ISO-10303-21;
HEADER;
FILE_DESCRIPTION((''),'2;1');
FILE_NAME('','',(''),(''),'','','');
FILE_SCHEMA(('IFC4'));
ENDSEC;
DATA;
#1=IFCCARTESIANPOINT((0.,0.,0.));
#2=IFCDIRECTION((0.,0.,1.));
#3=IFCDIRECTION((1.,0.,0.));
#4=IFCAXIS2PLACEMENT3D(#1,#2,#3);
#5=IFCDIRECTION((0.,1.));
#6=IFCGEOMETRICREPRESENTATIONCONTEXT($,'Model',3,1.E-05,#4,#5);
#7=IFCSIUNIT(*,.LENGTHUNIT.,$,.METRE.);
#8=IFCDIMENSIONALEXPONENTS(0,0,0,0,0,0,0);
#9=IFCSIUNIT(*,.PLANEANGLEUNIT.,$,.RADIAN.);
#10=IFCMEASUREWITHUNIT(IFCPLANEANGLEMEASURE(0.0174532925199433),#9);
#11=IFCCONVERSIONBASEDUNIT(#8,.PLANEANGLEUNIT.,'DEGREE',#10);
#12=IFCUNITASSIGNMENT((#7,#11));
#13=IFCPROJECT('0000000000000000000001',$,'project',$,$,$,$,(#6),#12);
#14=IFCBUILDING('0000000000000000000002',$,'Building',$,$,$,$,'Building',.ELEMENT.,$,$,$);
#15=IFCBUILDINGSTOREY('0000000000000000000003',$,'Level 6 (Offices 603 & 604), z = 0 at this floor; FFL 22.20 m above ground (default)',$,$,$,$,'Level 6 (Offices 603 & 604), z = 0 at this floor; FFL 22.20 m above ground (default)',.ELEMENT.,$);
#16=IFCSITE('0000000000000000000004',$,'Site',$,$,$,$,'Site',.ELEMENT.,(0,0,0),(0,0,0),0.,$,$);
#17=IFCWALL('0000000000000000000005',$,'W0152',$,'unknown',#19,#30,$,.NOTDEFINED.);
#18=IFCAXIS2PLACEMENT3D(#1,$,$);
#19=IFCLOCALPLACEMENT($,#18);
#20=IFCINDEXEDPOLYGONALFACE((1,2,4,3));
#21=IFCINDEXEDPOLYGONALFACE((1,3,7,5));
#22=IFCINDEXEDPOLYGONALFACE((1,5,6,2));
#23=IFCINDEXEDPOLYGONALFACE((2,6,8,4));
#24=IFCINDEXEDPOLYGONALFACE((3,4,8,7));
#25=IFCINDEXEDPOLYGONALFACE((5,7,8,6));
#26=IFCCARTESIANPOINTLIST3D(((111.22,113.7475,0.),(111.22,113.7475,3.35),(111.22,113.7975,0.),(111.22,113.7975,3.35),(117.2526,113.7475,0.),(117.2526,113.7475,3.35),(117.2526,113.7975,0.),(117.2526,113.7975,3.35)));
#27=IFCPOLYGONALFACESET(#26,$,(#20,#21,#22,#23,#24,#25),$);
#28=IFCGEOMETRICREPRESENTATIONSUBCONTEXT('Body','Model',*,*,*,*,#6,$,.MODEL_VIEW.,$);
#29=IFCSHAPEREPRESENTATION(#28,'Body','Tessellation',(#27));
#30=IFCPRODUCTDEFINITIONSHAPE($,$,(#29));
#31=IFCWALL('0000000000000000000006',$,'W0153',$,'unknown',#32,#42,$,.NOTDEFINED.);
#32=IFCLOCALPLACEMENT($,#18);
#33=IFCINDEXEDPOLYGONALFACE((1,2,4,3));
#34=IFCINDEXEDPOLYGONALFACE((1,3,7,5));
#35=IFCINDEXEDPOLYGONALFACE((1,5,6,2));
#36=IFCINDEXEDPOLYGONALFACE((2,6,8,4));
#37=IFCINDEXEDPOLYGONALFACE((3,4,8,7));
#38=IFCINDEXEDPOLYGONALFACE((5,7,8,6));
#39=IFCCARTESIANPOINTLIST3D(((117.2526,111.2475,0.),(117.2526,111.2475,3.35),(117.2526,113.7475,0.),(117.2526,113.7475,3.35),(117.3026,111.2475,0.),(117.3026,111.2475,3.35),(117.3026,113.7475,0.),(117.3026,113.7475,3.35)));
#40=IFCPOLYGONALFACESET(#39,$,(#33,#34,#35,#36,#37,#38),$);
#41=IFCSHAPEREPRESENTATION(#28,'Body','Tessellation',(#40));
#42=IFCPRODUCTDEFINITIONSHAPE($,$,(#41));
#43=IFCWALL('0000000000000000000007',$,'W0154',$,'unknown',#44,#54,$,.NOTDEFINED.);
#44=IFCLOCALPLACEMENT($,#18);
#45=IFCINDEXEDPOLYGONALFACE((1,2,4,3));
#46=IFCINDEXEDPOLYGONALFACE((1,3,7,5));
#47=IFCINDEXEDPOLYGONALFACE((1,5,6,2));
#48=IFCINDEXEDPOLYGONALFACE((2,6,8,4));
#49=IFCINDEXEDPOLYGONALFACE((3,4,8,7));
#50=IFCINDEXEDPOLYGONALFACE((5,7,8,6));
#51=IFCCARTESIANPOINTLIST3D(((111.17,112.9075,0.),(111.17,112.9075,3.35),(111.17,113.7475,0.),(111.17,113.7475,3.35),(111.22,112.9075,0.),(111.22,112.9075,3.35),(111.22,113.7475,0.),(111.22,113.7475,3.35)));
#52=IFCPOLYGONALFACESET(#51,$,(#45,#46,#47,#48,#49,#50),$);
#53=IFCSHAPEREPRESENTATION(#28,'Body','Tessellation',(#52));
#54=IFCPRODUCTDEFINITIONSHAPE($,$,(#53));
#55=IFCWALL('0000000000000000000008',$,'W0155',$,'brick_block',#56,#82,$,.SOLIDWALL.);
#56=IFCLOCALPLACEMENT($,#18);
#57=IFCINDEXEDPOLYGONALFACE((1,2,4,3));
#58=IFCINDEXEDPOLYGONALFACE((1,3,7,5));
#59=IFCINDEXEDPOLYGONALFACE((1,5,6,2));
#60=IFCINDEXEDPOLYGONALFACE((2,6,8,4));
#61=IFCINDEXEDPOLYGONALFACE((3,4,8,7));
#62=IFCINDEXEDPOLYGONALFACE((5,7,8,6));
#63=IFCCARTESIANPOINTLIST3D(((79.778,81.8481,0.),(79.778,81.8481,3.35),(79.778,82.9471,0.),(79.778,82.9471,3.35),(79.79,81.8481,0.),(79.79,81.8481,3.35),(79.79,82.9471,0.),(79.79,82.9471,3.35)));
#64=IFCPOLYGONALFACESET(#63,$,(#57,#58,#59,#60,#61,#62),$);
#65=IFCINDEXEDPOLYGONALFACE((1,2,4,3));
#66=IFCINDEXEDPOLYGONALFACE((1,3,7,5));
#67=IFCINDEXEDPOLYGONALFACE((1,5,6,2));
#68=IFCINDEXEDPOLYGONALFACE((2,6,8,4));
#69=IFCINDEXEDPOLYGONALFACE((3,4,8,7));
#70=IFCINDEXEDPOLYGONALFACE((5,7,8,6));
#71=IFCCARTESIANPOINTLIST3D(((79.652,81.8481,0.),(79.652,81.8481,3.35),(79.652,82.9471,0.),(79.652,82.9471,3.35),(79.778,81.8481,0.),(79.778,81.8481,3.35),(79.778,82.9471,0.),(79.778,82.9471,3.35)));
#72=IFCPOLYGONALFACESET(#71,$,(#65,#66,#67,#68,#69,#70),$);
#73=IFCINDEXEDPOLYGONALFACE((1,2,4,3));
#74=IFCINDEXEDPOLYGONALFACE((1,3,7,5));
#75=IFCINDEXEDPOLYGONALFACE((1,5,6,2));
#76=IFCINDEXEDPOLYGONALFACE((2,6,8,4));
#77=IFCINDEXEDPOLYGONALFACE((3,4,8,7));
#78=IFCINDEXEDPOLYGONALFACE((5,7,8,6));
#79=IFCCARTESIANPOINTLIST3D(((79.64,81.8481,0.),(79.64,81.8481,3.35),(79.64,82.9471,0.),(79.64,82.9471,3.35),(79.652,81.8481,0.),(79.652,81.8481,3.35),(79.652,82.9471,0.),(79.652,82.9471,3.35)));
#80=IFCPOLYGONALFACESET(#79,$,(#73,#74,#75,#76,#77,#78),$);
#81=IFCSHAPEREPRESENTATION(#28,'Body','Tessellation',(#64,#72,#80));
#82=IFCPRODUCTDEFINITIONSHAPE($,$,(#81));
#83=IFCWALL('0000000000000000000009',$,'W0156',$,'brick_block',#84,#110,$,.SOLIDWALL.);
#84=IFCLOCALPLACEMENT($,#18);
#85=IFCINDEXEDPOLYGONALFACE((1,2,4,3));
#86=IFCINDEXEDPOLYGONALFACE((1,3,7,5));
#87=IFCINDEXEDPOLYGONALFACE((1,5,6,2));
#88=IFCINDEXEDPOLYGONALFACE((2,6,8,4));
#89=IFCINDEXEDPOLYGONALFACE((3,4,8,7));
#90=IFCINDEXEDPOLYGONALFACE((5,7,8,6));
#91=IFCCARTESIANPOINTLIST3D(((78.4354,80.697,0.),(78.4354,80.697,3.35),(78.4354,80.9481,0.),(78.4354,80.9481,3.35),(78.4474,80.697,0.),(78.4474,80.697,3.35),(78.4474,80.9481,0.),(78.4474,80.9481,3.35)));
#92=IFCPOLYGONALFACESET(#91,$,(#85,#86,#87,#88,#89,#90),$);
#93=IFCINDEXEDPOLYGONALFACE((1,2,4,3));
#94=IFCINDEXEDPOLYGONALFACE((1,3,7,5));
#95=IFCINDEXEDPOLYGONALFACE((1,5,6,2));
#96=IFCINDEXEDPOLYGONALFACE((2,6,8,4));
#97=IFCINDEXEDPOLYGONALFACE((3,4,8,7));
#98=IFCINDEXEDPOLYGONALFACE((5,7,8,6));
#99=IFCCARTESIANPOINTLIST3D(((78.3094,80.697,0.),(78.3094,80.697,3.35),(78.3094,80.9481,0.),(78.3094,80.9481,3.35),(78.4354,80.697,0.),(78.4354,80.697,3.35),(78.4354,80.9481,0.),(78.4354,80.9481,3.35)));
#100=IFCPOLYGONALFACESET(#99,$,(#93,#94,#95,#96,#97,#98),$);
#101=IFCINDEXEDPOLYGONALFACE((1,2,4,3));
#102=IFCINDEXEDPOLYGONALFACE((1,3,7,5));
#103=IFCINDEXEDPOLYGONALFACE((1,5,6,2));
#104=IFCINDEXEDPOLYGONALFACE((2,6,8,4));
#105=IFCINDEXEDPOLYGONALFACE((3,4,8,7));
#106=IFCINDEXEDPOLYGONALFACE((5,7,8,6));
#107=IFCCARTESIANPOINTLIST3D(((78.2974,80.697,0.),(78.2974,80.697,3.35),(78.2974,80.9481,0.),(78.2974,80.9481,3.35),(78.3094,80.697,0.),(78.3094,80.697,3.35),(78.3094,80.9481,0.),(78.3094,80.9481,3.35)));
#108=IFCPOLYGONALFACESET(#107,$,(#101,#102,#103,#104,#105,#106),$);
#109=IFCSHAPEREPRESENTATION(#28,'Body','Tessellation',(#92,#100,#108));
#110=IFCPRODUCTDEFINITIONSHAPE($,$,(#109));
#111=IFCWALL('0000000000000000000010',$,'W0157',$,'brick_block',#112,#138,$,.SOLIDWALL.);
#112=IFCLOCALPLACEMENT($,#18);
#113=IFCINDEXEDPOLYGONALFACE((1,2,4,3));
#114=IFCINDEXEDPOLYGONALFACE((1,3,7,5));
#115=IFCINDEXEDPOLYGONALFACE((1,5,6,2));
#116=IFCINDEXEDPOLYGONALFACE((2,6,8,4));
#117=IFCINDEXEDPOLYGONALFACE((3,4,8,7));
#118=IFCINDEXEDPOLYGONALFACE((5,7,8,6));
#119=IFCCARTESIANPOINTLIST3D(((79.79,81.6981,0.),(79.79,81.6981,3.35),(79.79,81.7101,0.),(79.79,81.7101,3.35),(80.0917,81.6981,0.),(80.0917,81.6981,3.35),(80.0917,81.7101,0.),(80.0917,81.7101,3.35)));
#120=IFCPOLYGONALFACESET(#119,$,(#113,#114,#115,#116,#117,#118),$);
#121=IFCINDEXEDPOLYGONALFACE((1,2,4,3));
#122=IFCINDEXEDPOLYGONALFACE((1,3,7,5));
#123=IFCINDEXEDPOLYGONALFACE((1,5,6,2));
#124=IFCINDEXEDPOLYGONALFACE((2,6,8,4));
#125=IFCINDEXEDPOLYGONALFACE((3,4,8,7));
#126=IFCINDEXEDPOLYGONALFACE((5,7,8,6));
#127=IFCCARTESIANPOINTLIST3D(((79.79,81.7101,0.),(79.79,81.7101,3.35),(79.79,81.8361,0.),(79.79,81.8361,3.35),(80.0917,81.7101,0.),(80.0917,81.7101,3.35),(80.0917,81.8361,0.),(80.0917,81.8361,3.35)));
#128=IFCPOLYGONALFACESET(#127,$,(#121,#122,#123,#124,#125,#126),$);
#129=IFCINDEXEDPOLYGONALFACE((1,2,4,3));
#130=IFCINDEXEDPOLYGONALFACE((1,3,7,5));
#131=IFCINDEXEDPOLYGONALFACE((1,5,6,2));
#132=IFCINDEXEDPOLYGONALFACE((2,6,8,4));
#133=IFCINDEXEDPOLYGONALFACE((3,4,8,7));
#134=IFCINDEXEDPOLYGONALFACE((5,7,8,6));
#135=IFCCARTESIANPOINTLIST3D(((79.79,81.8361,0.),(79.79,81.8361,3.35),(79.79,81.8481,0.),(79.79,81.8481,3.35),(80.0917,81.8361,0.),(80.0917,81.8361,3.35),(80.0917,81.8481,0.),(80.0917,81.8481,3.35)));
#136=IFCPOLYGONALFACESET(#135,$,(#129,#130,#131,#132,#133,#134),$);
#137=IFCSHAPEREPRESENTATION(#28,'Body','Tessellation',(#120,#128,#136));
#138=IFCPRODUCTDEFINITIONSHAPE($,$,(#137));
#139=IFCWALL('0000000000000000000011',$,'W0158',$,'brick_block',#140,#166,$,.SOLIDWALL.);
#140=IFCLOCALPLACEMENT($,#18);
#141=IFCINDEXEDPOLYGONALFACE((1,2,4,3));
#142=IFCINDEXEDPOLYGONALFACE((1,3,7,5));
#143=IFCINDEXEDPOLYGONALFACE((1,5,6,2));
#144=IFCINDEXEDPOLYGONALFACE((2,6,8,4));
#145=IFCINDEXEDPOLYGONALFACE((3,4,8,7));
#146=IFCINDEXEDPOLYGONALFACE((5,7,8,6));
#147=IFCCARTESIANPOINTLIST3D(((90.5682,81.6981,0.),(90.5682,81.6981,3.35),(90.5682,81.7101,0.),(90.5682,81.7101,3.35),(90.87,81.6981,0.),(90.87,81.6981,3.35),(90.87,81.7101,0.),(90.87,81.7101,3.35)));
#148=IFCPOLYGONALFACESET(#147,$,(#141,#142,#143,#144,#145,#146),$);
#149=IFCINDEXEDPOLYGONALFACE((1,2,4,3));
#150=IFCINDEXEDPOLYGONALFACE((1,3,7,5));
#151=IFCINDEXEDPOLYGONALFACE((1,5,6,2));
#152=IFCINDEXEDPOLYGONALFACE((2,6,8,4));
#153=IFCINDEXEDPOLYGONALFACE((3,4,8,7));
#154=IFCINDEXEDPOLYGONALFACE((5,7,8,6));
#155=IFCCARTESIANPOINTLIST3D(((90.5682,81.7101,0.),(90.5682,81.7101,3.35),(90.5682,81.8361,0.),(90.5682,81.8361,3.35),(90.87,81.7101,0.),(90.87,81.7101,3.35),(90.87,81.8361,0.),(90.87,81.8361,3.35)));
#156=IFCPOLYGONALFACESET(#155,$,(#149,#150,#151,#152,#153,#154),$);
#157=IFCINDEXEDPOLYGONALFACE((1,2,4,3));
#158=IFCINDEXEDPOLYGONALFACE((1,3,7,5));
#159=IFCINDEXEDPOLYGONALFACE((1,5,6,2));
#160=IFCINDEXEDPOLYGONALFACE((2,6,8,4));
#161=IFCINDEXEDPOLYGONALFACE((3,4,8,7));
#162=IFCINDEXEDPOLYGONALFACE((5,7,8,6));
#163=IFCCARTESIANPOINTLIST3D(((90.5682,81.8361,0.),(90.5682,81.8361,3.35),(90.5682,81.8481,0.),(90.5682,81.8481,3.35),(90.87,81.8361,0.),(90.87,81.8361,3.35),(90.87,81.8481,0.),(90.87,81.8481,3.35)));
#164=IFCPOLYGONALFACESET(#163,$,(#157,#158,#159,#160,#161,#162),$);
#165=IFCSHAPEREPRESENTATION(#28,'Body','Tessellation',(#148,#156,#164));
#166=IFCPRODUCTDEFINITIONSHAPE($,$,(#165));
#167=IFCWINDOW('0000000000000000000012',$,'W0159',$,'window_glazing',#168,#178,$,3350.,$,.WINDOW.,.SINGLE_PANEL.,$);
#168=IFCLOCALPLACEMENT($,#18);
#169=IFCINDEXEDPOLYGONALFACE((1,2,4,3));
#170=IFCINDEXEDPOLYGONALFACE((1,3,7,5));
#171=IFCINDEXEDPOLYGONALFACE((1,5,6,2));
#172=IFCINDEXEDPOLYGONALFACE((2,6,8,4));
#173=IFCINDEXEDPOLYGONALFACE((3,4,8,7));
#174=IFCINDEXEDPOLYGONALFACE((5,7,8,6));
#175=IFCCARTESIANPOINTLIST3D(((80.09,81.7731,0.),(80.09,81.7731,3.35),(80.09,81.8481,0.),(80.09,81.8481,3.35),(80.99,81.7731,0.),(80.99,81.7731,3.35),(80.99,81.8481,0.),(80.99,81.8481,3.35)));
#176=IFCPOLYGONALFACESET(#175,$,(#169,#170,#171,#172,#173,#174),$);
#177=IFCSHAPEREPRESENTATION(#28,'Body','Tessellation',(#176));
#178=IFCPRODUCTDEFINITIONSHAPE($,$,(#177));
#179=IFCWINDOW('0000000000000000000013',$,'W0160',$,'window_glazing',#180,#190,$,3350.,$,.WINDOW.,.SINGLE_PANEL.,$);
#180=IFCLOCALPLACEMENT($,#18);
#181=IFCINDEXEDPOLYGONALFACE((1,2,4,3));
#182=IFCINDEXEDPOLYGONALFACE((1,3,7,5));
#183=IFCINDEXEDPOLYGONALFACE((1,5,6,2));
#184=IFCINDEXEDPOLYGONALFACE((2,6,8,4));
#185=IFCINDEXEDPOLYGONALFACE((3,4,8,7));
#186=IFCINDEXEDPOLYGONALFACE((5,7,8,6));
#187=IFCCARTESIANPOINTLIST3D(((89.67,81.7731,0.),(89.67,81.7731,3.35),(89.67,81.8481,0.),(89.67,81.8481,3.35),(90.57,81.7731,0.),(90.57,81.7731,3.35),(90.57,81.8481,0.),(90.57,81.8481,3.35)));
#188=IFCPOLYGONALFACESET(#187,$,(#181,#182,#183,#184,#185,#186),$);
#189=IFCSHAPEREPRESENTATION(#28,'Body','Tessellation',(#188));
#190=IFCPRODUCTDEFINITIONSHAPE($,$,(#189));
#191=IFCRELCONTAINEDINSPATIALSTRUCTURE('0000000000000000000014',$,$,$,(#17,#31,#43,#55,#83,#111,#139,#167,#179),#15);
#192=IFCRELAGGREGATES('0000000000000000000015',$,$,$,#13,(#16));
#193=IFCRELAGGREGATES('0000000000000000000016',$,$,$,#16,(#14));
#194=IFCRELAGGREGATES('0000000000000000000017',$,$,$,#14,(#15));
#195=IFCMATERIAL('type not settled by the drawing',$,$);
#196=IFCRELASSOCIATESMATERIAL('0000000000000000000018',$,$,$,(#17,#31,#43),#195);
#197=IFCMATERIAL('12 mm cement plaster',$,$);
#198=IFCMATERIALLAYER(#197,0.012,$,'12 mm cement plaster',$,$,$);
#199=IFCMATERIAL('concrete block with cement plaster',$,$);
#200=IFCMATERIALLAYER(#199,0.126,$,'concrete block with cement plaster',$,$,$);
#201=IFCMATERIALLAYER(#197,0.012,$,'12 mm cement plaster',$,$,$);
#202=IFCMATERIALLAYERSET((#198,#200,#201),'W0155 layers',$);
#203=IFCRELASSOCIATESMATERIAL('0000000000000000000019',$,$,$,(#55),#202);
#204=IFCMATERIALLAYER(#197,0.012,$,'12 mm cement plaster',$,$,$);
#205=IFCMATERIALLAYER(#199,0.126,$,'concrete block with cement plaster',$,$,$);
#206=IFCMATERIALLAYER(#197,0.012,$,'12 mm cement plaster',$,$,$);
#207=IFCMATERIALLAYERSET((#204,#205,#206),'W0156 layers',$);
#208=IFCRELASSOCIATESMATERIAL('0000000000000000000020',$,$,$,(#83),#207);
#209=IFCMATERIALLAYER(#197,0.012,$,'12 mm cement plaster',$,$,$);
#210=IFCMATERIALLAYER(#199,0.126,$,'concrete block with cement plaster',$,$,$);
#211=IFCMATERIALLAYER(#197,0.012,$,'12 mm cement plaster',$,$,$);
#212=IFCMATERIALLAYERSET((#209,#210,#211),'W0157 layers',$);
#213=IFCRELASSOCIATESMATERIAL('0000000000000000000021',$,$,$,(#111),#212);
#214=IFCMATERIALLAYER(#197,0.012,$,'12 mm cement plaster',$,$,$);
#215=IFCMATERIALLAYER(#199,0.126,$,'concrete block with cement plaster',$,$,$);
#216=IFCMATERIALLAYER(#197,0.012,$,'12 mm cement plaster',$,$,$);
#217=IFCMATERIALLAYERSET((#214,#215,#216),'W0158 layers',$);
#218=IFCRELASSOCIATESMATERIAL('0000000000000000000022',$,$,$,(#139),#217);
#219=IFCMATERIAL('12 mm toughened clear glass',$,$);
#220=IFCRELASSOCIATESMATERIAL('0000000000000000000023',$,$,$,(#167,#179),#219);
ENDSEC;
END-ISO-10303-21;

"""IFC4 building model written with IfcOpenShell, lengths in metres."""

from ifc_helpers import new_model, entity, si_unit, converted_unit, direction, frame, frame_2d, origin_with_axes, origin_2d_with_axis, place, context, subcontext, project, spatial, rectangle, extrude, material, layer, layer_set, layer_usage, element, save


model = new_model("IFC4")

# Units and contexts
model_context = context("Model", 3, precision=1e-05, world=origin_with_axes(), true_north=direction((0.0, 1.0)))
body_context = subcontext(model_context, "Body", "Model", "MODEL_VIEW")
ifc_project = project(units=[si_unit("LENGTHUNIT", "METRE"), converted_unit("PLANEANGLEUNIT", "DEGREE", entity("IfcPlaneAngleMeasure", 0.0174532925199433), si_unit("PLANEANGLEUNIT", "RADIAN"), dimensions=[0, 0, 0, 0, 0, 0, 0])], contexts=[model_context])

# Site, building, storey
site = spatial("IfcSite", under=ifc_project, Name="Site", LongName="Site", CompositionType="ELEMENT", RefLatitude=(0, 0, 0), RefLongitude=(0, 0, 0), RefElevation=0.0)
building = spatial("IfcBuilding", under=site, Name="Building", LongName="Building", CompositionType="ELEMENT")
storey = spatial("IfcBuildingStorey", under=building, Name="Level 6 (Offices 603 & 604), z = 0 at this floor; FFL 22.20 m above ground (default)", LongName="Level 6 (Offices 603 & 604), z = 0 at this floor; FFL 22.20 m above ground (default)", CompositionType="ELEMENT")

# Shared definitions
ifc_material_1 = material(Name="12 mm cement plaster")
ifc_material_2 = material(Name="concrete block with cement plaster")
placement = place(None, origin_with_axes())

# Shared definitions
ifc_material_3 = material(Name="12 mm toughened clear glass")

# Walls
ifc_material_4 = material(Name="type not settled by the drawing")
element("IfcWall", 1, at=placement, inside=storey, material=ifc_material_4, Name="W0152", ObjectType="unknown", PredefinedType="NOTDEFINED", context=body_context, shape_type="SweptSolid", body=[
    extrude(rectangle(XDim=6.0326, YDim=0.05, at=frame_2d((0.0, 0.0), x_axis=(1.0, 0.0))), frame((114.2363, 113.7725, 0.0), z_axis=(0.0, 0.0, 1.0), x_axis=(1.0, 0.0, 0.0)), (0.0, 0.0, 1.0), 3.35),
])
element("IfcWall", 2, at=placement, inside=storey, material=ifc_material_4, Name="W0153", ObjectType="unknown", PredefinedType="NOTDEFINED", context=body_context, shape_type="SweptSolid", body=[
    extrude(rectangle(XDim=2.5, YDim=0.05, at=frame_2d((0.0, 0.0), x_axis=(0.0, 1.0))), frame((117.2776, 112.4975, 0.0), z_axis=(0.0, 0.0, 1.0), x_axis=(1.0, 0.0, 0.0)), (0.0, 0.0, 1.0), 3.35),
])
element("IfcWall", 3, at=placement, inside=storey, material=ifc_material_4, Name="W0154", ObjectType="unknown", PredefinedType="NOTDEFINED", context=body_context, shape_type="SweptSolid", body=[
    extrude(rectangle(XDim=0.84, YDim=0.05, at=frame_2d((0.0, 0.0), x_axis=(0.0, 1.0))), frame((111.195, 113.3275, 0.0), z_axis=(0.0, 0.0, 1.0), x_axis=(1.0, 0.0, 0.0)), (0.0, 0.0, 1.0), 3.35),
])
ifc_layer_1 = layer(ifc_material_1, 0.012, Name="12 mm cement plaster")
ifc_layer_2 = layer(ifc_material_2, 0.126, Name="concrete block with cement plaster")
ifc_layer_3 = layer(ifc_material_1, 0.012, Name="12 mm cement plaster")
ifc_layer_set_1 = layer_set([ifc_layer_1, ifc_layer_2, ifc_layer_3], Name="W0155 layers")
ifc_layer_usage_1 = layer_usage(ifc_layer_set_1, "AXIS2", "POSITIVE", -0.075)
element("IfcWall", 4, at=placement, inside=storey, material=ifc_layer_usage_1, Name="W0155", ObjectType="brick_block", PredefinedType="SOLIDWALL", context=body_context, shape_type="SweptSolid", body=[
    extrude(rectangle(XDim=1.099, YDim=0.012, at=frame_2d((0.0, 0.0), x_axis=(0.0, 1.0))), frame((79.784, 82.3976, 0.0), z_axis=(0.0, 0.0, 1.0), x_axis=(1.0, 0.0, 0.0)), (0.0, 0.0, 1.0), 3.35),
    extrude(rectangle(XDim=1.099, YDim=0.126, at=frame_2d((-0.069, 0.0), x_axis=(0.0, 1.0))), frame((79.784, 82.3976, 0.0), z_axis=(0.0, 0.0, 1.0), x_axis=(1.0, 0.0, 0.0)), (0.0, 0.0, 1.0), 3.35),
    extrude(rectangle(XDim=1.099, YDim=0.012, at=frame_2d((-0.138, 0.0), x_axis=(0.0, 1.0))), frame((79.784, 82.3976, 0.0), z_axis=(0.0, 0.0, 1.0), x_axis=(1.0, 0.0, 0.0)), (0.0, 0.0, 1.0), 3.35),
])
ifc_layer_4 = layer(ifc_material_1, 0.012, Name="12 mm cement plaster")
ifc_layer_5 = layer(ifc_material_2, 0.126, Name="concrete block with cement plaster")
ifc_layer_6 = layer(ifc_material_1, 0.012, Name="12 mm cement plaster")
ifc_layer_set_2 = layer_set([ifc_layer_4, ifc_layer_5, ifc_layer_6], Name="W0156 layers")
ifc_layer_usage_2 = layer_usage(ifc_layer_set_2, "AXIS2", "POSITIVE", -0.075)
element("IfcWall", 5, at=placement, inside=storey, material=ifc_layer_usage_2, Name="W0156", ObjectType="brick_block", PredefinedType="SOLIDWALL", context=body_context, shape_type="SweptSolid", body=[
    extrude(rectangle(XDim=0.2511, YDim=0.012, at=frame_2d((0.0, 0.0), x_axis=(0.0, 1.0))), frame((78.4414, 80.8226, 0.0), z_axis=(0.0, 0.0, 1.0), x_axis=(1.0, 0.0, 0.0)), (0.0, 0.0, 1.0), 3.35),
    extrude(rectangle(XDim=0.2511, YDim=0.126, at=frame_2d((-0.069, 0.0), x_axis=(0.0, 1.0))), frame((78.4414, 80.8226, 0.0), z_axis=(0.0, 0.0, 1.0), x_axis=(1.0, 0.0, 0.0)), (0.0, 0.0, 1.0), 3.35),
    extrude(rectangle(XDim=0.2511, YDim=0.012, at=frame_2d((-0.138, 0.0), x_axis=(0.0, 1.0))), frame((78.4414, 80.8226, 0.0), z_axis=(0.0, 0.0, 1.0), x_axis=(1.0, 0.0, 0.0)), (0.0, 0.0, 1.0), 3.35),
])
ifc_layer_7 = layer(ifc_material_1, 0.012, Name="12 mm cement plaster")
ifc_layer_8 = layer(ifc_material_2, 0.126, Name="concrete block with cement plaster")
ifc_layer_9 = layer(ifc_material_1, 0.012, Name="12 mm cement plaster")
ifc_layer_set_3 = layer_set([ifc_layer_7, ifc_layer_8, ifc_layer_9], Name="W0157 layers")
ifc_layer_usage_3 = layer_usage(ifc_layer_set_3, "AXIS2", "POSITIVE", -0.075)
element("IfcWall", 6, at=placement, inside=storey, material=ifc_layer_usage_3, Name="W0157", ObjectType="brick_block", PredefinedType="SOLIDWALL", context=body_context, shape_type="SweptSolid", body=[
    extrude(rectangle(XDim=0.3017, YDim=0.012, at=origin_2d_with_axis()), frame((79.9408, 81.7041, 0.0), z_axis=(0.0, 0.0, 1.0), x_axis=(1.0, 0.0, 0.0)), (0.0, 0.0, 1.0), 3.35),
    extrude(rectangle(XDim=0.3017, YDim=0.126, at=frame_2d((0.0, 0.069), x_axis=(1.0, 0.0))), frame((79.9408, 81.7041, 0.0), z_axis=(0.0, 0.0, 1.0), x_axis=(1.0, 0.0, 0.0)), (0.0, 0.0, 1.0), 3.35),
    extrude(rectangle(XDim=0.3017, YDim=0.012, at=frame_2d((0.0, 0.138), x_axis=(1.0, 0.0))), frame((79.9408, 81.7041, 0.0), z_axis=(0.0, 0.0, 1.0), x_axis=(1.0, 0.0, 0.0)), (0.0, 0.0, 1.0), 3.35),
])
ifc_layer_10 = layer(ifc_material_1, 0.012, Name="12 mm cement plaster")
ifc_layer_11 = layer(ifc_material_2, 0.126, Name="concrete block with cement plaster")
ifc_layer_12 = layer(ifc_material_1, 0.012, Name="12 mm cement plaster")
ifc_layer_set_4 = layer_set([ifc_layer_10, ifc_layer_11, ifc_layer_12], Name="W0158 layers")
ifc_layer_usage_4 = layer_usage(ifc_layer_set_4, "AXIS2", "POSITIVE", -0.075)
element("IfcWall", 7, at=placement, inside=storey, material=ifc_layer_usage_4, Name="W0158", ObjectType="brick_block", PredefinedType="SOLIDWALL", context=body_context, shape_type="SweptSolid", body=[
    extrude(rectangle(XDim=0.3018, YDim=0.012, at=origin_2d_with_axis()), frame((90.7191, 81.7041, 0.0), z_axis=(0.0, 0.0, 1.0), x_axis=(1.0, 0.0, 0.0)), (0.0, 0.0, 1.0), 3.35),
    extrude(rectangle(XDim=0.3018, YDim=0.126, at=frame_2d((0.0, 0.069), x_axis=(1.0, 0.0))), frame((90.7191, 81.7041, 0.0), z_axis=(0.0, 0.0, 1.0), x_axis=(1.0, 0.0, 0.0)), (0.0, 0.0, 1.0), 3.35),
    extrude(rectangle(XDim=0.3018, YDim=0.012, at=frame_2d((0.0, 0.138), x_axis=(1.0, 0.0))), frame((90.7191, 81.7041, 0.0), z_axis=(0.0, 0.0, 1.0), x_axis=(1.0, 0.0, 0.0)), (0.0, 0.0, 1.0), 3.35),
])

# Windows
element("IfcWindow", 8, at=placement, inside=storey, material=ifc_material_3, Name="W0159", ObjectType="window_glazing", OverallHeight=3350.0, PartitioningType="SINGLE_PANEL", PredefinedType="WINDOW", context=body_context, shape_type="SweptSolid", body=[
    extrude(rectangle(XDim=0.9, YDim=0.075, at=frame_2d((0.0, 0.0), x_axis=(1.0, 0.0))), frame((80.54, 81.8106, 0.0), z_axis=(0.0, 0.0, 1.0), x_axis=(1.0, 0.0, 0.0)), (0.0, 0.0, 1.0), 3.35),
])
element("IfcWindow", 9, at=placement, inside=storey, material=ifc_material_3, Name="W0160", ObjectType="window_glazing", OverallHeight=3350.0, PartitioningType="SINGLE_PANEL", PredefinedType="WINDOW", context=body_context, shape_type="SweptSolid", body=[
    extrude(rectangle(XDim=0.9, YDim=0.075, at=frame_2d((0.0, 0.0), x_axis=(1.0, 0.0))), frame((90.12, 81.8106, 0.0), z_axis=(0.0, 0.0, 1.0), x_axis=(1.0, 0.0, 0.0)), (0.0, 0.0, 1.0), 3.35),
])

save(model, "model.ifc")
